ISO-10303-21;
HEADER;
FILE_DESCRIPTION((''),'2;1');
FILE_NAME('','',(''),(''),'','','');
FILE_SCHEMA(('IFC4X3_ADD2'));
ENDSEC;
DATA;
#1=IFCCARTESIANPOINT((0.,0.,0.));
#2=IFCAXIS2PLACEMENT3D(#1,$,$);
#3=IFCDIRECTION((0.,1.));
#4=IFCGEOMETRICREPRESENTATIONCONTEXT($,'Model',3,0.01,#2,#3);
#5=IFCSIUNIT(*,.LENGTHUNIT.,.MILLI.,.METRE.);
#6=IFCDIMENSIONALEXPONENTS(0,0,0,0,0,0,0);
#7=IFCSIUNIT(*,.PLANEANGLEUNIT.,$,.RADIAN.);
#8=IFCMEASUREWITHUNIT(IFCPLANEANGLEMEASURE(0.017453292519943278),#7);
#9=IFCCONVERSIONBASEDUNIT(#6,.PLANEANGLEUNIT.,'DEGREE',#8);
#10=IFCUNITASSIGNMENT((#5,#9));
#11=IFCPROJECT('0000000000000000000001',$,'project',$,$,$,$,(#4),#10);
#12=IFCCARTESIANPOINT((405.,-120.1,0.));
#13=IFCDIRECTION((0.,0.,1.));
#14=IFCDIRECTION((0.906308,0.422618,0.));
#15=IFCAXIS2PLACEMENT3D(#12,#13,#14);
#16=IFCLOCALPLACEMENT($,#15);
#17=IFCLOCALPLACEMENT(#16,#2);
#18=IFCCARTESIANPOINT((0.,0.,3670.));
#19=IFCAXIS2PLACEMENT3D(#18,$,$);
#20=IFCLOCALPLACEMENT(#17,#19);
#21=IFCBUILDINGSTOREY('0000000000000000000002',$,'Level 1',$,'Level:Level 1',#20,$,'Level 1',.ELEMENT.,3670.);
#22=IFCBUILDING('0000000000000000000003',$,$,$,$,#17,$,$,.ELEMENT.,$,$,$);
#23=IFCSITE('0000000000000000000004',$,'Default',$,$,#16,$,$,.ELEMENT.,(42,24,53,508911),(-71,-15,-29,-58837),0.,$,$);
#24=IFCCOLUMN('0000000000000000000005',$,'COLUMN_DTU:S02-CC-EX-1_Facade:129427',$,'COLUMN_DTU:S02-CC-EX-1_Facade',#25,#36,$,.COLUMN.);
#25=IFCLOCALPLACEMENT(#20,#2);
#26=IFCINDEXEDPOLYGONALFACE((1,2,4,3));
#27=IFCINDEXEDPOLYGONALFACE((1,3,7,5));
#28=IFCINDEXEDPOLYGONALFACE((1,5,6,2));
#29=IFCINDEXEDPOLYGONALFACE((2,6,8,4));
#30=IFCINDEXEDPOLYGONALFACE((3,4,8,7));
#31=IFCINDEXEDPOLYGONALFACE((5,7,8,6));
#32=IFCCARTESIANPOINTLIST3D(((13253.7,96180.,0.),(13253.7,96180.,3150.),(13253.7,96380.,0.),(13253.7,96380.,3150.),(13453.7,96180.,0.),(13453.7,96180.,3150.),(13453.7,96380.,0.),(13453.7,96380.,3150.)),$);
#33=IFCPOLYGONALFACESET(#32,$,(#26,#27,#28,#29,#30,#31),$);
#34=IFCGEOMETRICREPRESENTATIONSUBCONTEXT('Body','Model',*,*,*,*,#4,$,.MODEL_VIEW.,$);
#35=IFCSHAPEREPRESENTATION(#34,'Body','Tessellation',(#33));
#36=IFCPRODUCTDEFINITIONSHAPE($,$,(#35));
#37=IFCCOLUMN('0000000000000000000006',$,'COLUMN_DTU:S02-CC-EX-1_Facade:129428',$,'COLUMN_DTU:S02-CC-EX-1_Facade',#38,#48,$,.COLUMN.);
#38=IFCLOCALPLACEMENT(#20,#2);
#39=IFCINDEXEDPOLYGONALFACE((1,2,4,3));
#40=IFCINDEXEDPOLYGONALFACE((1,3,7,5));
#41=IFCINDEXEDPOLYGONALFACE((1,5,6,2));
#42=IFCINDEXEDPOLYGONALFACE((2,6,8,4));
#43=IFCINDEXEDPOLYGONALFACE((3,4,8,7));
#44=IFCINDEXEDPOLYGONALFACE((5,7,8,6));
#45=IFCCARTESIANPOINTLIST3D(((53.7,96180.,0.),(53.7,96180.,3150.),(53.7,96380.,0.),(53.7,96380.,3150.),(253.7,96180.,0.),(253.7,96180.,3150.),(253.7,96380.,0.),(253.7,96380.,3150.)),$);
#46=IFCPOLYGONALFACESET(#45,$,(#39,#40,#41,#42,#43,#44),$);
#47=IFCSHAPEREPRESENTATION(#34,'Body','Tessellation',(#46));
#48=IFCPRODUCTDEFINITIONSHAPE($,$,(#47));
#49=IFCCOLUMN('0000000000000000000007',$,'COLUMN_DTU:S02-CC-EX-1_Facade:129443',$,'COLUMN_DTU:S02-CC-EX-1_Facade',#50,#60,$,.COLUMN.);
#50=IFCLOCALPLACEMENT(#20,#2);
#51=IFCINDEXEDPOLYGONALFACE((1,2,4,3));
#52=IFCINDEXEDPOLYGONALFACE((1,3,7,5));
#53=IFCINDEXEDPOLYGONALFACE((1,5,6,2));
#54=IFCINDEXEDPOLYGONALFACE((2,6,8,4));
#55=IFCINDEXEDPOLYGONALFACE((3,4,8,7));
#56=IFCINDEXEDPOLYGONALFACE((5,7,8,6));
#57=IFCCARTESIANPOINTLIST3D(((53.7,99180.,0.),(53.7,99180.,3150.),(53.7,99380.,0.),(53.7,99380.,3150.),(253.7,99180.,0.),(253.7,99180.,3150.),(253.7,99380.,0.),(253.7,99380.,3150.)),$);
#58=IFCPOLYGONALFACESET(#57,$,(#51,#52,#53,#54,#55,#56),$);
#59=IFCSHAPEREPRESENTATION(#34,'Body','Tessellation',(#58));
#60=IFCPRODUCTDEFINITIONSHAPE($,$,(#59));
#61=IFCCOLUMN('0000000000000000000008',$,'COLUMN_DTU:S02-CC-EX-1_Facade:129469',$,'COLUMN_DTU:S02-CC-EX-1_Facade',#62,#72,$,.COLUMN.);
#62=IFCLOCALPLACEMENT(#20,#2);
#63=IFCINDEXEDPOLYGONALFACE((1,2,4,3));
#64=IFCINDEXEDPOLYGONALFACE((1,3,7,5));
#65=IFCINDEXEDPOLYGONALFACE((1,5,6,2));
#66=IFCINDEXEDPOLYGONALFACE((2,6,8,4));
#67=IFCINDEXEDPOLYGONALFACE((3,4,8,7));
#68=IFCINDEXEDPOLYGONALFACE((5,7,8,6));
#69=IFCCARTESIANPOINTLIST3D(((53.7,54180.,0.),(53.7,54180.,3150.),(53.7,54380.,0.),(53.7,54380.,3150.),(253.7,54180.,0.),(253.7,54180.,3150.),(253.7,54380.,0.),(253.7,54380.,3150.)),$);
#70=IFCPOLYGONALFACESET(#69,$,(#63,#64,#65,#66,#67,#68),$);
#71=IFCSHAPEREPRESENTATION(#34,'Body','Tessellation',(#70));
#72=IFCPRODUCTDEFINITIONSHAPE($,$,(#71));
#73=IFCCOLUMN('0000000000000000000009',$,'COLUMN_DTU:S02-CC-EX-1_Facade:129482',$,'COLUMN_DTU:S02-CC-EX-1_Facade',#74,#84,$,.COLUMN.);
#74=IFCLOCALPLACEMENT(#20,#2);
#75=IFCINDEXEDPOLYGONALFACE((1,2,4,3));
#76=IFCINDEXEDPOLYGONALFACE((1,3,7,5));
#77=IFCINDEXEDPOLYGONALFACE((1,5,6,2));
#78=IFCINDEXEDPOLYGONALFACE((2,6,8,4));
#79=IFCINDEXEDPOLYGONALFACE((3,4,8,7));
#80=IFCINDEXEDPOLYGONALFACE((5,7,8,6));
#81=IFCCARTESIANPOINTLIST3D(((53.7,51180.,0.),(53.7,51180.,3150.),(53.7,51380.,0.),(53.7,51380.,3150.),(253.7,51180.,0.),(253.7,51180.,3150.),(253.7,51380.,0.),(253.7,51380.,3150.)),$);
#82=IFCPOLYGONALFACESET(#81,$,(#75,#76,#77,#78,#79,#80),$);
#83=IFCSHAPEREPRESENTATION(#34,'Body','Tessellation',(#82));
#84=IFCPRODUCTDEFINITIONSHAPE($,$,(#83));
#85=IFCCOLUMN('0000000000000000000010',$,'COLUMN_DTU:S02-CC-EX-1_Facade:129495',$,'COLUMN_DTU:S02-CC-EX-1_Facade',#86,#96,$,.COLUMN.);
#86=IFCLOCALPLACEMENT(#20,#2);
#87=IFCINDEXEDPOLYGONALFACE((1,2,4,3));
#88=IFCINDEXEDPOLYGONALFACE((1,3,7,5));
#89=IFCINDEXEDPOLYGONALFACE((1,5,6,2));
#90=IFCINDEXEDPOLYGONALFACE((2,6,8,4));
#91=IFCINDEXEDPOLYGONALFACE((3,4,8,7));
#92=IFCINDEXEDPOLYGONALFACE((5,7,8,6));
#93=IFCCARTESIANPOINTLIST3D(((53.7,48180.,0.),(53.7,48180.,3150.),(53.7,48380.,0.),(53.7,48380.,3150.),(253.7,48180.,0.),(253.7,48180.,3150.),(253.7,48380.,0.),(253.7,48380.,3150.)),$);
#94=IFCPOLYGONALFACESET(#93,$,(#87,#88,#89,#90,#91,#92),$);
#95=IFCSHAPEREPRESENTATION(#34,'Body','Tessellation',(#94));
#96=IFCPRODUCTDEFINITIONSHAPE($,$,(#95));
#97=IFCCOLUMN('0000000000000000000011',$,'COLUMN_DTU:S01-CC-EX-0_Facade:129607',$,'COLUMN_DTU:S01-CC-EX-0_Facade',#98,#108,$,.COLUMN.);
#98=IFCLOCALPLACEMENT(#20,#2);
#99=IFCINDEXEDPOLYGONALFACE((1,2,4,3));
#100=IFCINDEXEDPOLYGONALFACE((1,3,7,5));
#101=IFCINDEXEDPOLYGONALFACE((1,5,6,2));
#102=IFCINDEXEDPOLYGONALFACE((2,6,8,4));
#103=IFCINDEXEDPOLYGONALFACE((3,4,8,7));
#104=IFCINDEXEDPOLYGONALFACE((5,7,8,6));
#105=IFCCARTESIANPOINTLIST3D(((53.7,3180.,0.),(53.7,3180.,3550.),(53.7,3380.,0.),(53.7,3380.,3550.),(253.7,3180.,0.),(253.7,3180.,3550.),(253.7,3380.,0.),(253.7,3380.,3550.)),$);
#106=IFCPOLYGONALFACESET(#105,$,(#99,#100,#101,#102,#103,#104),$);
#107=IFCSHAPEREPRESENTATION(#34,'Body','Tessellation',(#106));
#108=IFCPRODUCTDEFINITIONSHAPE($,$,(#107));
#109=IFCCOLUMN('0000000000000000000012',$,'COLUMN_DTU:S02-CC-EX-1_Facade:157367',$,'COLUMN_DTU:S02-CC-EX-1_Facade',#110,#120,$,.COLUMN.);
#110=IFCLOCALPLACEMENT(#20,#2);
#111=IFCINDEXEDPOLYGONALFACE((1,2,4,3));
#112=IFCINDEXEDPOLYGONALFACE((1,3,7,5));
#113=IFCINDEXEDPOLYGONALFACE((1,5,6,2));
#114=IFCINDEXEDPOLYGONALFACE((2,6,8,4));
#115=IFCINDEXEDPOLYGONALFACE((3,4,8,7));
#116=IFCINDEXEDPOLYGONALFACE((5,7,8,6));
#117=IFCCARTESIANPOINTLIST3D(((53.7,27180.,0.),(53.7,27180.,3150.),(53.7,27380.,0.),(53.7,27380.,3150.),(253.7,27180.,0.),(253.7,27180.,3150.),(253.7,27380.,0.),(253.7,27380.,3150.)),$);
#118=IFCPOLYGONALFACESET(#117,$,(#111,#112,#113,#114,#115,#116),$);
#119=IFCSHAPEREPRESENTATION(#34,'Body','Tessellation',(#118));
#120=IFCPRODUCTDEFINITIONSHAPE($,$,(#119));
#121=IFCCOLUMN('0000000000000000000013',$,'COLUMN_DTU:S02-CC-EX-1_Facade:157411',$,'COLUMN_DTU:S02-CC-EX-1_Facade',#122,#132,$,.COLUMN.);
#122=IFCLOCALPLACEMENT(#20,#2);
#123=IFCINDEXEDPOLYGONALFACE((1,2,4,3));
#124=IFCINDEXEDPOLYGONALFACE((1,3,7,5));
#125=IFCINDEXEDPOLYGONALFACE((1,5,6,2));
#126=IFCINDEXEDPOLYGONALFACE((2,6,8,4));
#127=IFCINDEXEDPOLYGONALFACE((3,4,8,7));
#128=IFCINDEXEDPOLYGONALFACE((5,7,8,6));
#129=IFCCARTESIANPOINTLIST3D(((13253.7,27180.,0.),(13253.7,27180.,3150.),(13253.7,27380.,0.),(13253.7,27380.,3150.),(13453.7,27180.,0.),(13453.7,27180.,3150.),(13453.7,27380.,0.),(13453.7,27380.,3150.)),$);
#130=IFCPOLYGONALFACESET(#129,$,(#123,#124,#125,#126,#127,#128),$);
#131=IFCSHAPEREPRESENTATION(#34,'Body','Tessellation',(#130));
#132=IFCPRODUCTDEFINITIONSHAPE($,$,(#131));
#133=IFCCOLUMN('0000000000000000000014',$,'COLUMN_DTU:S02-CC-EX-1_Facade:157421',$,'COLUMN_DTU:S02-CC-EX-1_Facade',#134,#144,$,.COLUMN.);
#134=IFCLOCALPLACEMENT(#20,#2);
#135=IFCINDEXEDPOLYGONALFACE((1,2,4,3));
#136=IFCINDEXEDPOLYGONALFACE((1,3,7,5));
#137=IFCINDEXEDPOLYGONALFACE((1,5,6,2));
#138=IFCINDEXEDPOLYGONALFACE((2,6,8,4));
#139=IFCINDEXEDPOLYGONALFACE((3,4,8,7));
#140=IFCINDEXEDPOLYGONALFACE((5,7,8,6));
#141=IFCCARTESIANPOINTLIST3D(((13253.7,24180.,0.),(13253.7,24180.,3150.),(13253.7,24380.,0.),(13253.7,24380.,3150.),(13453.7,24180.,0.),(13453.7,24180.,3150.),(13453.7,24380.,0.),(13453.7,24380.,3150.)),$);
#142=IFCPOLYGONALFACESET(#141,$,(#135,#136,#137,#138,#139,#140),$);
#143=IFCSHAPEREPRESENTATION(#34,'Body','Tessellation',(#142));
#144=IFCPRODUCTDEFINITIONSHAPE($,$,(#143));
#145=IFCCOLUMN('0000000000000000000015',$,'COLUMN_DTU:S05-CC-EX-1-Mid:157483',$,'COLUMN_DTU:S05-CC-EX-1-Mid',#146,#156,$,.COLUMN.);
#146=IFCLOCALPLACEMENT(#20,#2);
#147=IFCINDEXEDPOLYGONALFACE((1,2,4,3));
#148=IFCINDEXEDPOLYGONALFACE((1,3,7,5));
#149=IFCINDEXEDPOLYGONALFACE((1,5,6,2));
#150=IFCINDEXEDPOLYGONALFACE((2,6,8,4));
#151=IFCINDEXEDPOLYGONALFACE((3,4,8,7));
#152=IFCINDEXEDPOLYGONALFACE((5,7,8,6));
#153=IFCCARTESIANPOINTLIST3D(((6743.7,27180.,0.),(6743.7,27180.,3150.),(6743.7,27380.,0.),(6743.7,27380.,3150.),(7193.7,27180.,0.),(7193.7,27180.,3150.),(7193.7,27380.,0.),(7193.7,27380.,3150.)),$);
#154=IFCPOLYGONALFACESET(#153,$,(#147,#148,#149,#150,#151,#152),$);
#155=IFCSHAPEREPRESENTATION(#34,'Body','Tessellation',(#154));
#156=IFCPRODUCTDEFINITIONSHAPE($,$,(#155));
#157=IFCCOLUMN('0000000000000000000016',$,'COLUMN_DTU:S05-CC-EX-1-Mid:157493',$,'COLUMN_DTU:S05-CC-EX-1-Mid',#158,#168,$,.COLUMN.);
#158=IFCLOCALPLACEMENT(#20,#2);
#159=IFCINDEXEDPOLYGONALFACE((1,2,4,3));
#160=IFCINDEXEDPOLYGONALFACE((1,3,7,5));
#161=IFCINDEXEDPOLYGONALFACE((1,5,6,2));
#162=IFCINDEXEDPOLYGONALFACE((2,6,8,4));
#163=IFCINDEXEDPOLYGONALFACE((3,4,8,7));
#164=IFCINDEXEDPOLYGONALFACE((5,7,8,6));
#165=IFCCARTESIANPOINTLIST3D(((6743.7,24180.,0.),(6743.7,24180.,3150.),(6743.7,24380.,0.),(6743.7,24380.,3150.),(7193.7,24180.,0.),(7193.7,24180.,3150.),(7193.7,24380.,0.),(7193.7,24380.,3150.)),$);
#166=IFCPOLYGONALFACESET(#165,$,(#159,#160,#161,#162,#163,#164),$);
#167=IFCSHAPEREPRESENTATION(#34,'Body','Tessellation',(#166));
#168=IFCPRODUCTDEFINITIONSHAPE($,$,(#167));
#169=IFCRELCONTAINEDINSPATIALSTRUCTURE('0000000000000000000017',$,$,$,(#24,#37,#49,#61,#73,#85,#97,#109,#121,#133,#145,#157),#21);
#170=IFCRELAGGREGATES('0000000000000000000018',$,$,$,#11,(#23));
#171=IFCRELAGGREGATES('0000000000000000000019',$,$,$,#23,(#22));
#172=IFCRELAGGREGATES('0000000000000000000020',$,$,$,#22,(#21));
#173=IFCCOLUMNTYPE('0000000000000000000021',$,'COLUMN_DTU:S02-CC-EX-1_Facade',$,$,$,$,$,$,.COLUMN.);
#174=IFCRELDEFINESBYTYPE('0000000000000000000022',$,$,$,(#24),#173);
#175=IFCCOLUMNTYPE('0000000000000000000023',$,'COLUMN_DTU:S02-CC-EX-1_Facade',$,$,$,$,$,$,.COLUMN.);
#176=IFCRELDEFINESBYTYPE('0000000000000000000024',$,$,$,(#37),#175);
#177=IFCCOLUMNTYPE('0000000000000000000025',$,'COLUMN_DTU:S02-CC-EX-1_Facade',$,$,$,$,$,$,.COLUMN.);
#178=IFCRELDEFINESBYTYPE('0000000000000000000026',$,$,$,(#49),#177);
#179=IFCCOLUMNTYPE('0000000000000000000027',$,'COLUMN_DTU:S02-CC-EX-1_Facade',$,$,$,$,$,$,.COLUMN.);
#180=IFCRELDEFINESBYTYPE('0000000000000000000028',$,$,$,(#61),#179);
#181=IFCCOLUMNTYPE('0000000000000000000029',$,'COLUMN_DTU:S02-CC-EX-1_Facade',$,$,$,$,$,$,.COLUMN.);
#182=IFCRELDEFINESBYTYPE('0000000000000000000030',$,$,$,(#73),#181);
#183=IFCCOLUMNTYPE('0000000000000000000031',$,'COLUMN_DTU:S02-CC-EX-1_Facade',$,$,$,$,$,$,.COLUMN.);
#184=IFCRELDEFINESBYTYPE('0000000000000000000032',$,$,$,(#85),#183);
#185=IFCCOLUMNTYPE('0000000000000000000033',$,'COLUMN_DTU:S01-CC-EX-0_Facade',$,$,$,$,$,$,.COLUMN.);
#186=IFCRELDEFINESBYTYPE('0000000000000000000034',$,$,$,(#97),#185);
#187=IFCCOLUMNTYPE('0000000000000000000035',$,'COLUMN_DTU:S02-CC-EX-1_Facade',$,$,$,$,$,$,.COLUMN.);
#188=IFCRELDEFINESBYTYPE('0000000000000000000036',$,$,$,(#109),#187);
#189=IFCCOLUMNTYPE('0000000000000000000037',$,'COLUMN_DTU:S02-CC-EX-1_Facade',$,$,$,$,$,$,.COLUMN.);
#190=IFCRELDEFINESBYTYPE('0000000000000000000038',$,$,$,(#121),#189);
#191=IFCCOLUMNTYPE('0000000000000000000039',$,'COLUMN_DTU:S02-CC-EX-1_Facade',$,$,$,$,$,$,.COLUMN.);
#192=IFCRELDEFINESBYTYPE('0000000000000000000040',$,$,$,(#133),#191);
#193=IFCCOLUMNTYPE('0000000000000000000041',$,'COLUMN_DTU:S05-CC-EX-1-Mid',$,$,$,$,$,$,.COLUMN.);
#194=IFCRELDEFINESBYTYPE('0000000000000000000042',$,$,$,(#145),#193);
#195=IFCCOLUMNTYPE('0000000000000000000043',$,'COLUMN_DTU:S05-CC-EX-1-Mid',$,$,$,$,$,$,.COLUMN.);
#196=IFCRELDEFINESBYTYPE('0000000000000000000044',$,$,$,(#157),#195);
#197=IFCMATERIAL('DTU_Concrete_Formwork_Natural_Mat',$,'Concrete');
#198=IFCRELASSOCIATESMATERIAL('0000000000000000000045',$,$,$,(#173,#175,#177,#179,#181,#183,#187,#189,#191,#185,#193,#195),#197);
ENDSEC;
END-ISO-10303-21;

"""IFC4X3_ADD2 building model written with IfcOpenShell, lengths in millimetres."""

from ifc_helpers import new_model, entity, si_unit, converted_unit, direction, frame, frame_2d, origin, origin_2d_with_axis, place, context, subcontext, project, spatial, rectangle, extrude, source, transform, mapped, material, material_profile, profile_set, type_object, type_shapes, element, save


model = new_model("IFC4X3_ADD2")

# Units and contexts
model_context = context("Model", 3, precision=0.01, world=origin(), true_north=direction((0.0, 1.0)))
body_context = subcontext(model_context, "Body", "Model", "MODEL_VIEW")
ifc_project = project(units=[si_unit("LENGTHUNIT", "METRE", prefix="MILLI"), converted_unit("PLANEANGLEUNIT", "DEGREE", entity("IfcPlaneAngleMeasure", 0.017453292519943278), si_unit("PLANEANGLEUNIT", "RADIAN"), dimensions=[0, 0, 0, 0, 0, 0, 0])], contexts=[model_context])

# Site, building, storey
site_placement = place(None, frame((405.0, -120.1, 0.0), z_axis=(0.0, 0.0, 1.0), x_axis=(0.906308, 0.422618, 0.0)))
site = spatial("IfcSite", under=ifc_project, at=site_placement, Name="Default", CompositionType="ELEMENT", RefLatitude=(42, 24, 53, 508911), RefLongitude=(-71, -15, -29, -58837), RefElevation=0.0)
building_placement = place(site_placement, origin())
building = spatial("IfcBuilding", under=site, at=building_placement, CompositionType="ELEMENT")
storey_placement = place(building_placement, frame((0.0, 0.0, 3670.0)))
storey = spatial("IfcBuildingStorey", under=building, at=storey_placement, Name="Level 1", ObjectType="Level:Level 1", LongName="Level 1", CompositionType="ELEMENT", Elevation=3670.0)

# Columns
ifc_material = material(Name="DTU_Concrete_Formwork_Natural_Mat", Category="Concrete")
ifc_material_profile_1 = material_profile(ifc_material, rectangle(XDim=200.0, YDim=200.0, at=frame_2d((0.0, 0.0), x_axis=(1.0, 0.0))), Name="S02-CC-EX-1_Facade")
ifc_profile_set_1 = profile_set([ifc_material_profile_1], Name="S02-CC-EX-1_Facade")
column_type_1 = type_object("IfcColumnType", Name="COLUMN_DTU:S02-CC-EX-1_Facade", PredefinedType="COLUMN", material=ifc_profile_set_1)
shared_shape_1 = source(origin(), body_context, "Body", "SweptSolid", [
    extrude(rectangle(XDim=200.0, YDim=200.0, at=frame_2d((0.0, 0.0), x_axis=(1.0, 0.0))), frame((13353.7, 96280.0, 3670.0), z_axis=(0.0, 0.0, 1.0), x_axis=(0.0, -1.0, 0.0)), (0.0, 0.0, 1.0), 3150.0),
])
type_shapes(column_type_1, [shared_shape_1])
column_1_placement = place(storey_placement, frame((0.0, 0.0, -3670.0)))
element("IfcColumn", 1, at=column_1_placement, inside=storey, type_object=column_type_1, Name="COLUMN_DTU:S02-CC-EX-1_Facade:129427", ObjectType="COLUMN_DTU:S02-CC-EX-1_Facade", PredefinedType="COLUMN", context=body_context, shape_type="MappedRepresentation", body=[
    mapped(shared_shape_1, transform((0.0, 0.0, 0.0), scale=1.0)),
])
column_type_2 = type_object("IfcColumnType", Name="COLUMN_DTU:S02-CC-EX-1_Facade", PredefinedType="COLUMN", material=ifc_profile_set_1)
shared_shape_2 = source(origin(), body_context, "Body", "SweptSolid", [
    extrude(rectangle(XDim=200.0, YDim=200.0, at=frame_2d((0.0, 0.0), x_axis=(1.0, 0.0))), frame((153.7, 96280.0, 3670.0), z_axis=(0.0, 0.0, 1.0), x_axis=(0.0, -1.0, 0.0)), (0.0, 0.0, 1.0), 3150.0),
])
type_shapes(column_type_2, [shared_shape_2])
column_2_placement = place(storey_placement, frame((0.0, 0.0, -3670.0)))
element("IfcColumn", 2, at=column_2_placement, inside=storey, type_object=column_type_2, Name="COLUMN_DTU:S02-CC-EX-1_Facade:129428", ObjectType="COLUMN_DTU:S02-CC-EX-1_Facade", PredefinedType="COLUMN", context=body_context, shape_type="MappedRepresentation", body=[
    mapped(shared_shape_2, transform((0.0, 0.0, 0.0), scale=1.0)),
])
column_type_3 = type_object("IfcColumnType", Name="COLUMN_DTU:S02-CC-EX-1_Facade", PredefinedType="COLUMN", material=ifc_profile_set_1)
shared_shape_3 = source(origin(), body_context, "Body", "SweptSolid", [
    extrude(rectangle(XDim=200.0, YDim=200.0, at=frame_2d((0.0, 0.0), x_axis=(1.0, 0.0))), frame((153.7, 99280.0, 3670.0), z_axis=(0.0, 0.0, 1.0), x_axis=(0.0, -1.0, 0.0)), (0.0, 0.0, 1.0), 3150.0),
])
type_shapes(column_type_3, [shared_shape_3])
column_3_placement = place(storey_placement, frame((0.0, 0.0, -3670.0)))
element("IfcColumn", 3, at=column_3_placement, inside=storey, type_object=column_type_3, Name="COLUMN_DTU:S02-CC-EX-1_Facade:129443", ObjectType="COLUMN_DTU:S02-CC-EX-1_Facade", PredefinedType="COLUMN", context=body_context, shape_type="MappedRepresentation", body=[
    mapped(shared_shape_3, transform((0.0, 0.0, 0.0), scale=1.0)),
])
column_type_4 = type_object("IfcColumnType", Name="COLUMN_DTU:S02-CC-EX-1_Facade", PredefinedType="COLUMN", material=ifc_profile_set_1)
shared_shape_4 = source(origin(), body_context, "Body", "SweptSolid", [
    extrude(rectangle(XDim=200.0, YDim=200.0, at=frame_2d((0.0, 0.0), x_axis=(1.0, 0.0))), frame((153.7, 54280.0, 3670.0), z_axis=(0.0, 0.0, 1.0), x_axis=(0.0, -1.0, 0.0)), (0.0, 0.0, 1.0), 3150.0),
])
type_shapes(column_type_4, [shared_shape_4])
column_4_placement = place(storey_placement, frame((0.0, 0.0, -3670.0)))
element("IfcColumn", 4, at=column_4_placement, inside=storey, type_object=column_type_4, Name="COLUMN_DTU:S02-CC-EX-1_Facade:129469", ObjectType="COLUMN_DTU:S02-CC-EX-1_Facade", PredefinedType="COLUMN", context=body_context, shape_type="MappedRepresentation", body=[
    mapped(shared_shape_4, transform((0.0, 0.0, 0.0), scale=1.0)),
])
column_type_5 = type_object("IfcColumnType", Name="COLUMN_DTU:S02-CC-EX-1_Facade", PredefinedType="COLUMN", material=ifc_profile_set_1)
shared_shape_5 = source(origin(), body_context, "Body", "SweptSolid", [
    extrude(rectangle(XDim=200.0, YDim=200.0, at=frame_2d((0.0, 0.0), x_axis=(1.0, 0.0))), frame((153.7, 51280.0, 3670.0), z_axis=(0.0, 0.0, 1.0), x_axis=(0.0, -1.0, 0.0)), (0.0, 0.0, 1.0), 3150.0),
])
type_shapes(column_type_5, [shared_shape_5])
column_5_placement = place(storey_placement, frame((0.0, 0.0, -3670.0)))
element("IfcColumn", 5, at=column_5_placement, inside=storey, type_object=column_type_5, Name="COLUMN_DTU:S02-CC-EX-1_Facade:129482", ObjectType="COLUMN_DTU:S02-CC-EX-1_Facade", PredefinedType="COLUMN", context=body_context, shape_type="MappedRepresentation", body=[
    mapped(shared_shape_5, transform((0.0, 0.0, 0.0), scale=1.0)),
])
column_type_6 = type_object("IfcColumnType", Name="COLUMN_DTU:S02-CC-EX-1_Facade", PredefinedType="COLUMN", material=ifc_profile_set_1)
shared_shape_6 = source(origin(), body_context, "Body", "SweptSolid", [
    extrude(rectangle(XDim=200.0, YDim=200.0, at=frame_2d((0.0, 0.0), x_axis=(1.0, 0.0))), frame((153.7, 48280.0, 3670.0), z_axis=(0.0, 0.0, 1.0), x_axis=(0.0, -1.0, 0.0)), (0.0, 0.0, 1.0), 3150.0),
])
type_shapes(column_type_6, [shared_shape_6])
column_6_placement = place(storey_placement, frame((0.0, 0.0, -3670.0)))
element("IfcColumn", 6, at=column_6_placement, inside=storey, type_object=column_type_6, Name="COLUMN_DTU:S02-CC-EX-1_Facade:129495", ObjectType="COLUMN_DTU:S02-CC-EX-1_Facade", PredefinedType="COLUMN", context=body_context, shape_type="MappedRepresentation", body=[
    mapped(shared_shape_6, transform((0.0, 0.0, 0.0), scale=1.0)),
])
ifc_material_profile_2 = material_profile(ifc_material, rectangle(XDim=200.0, YDim=200.0, at=frame_2d((0.0, 0.0), x_axis=(1.0, 0.0))), Name="S01-CC-EX-0_Facade")
ifc_profile_set_2 = profile_set([ifc_material_profile_2], Name="S01-CC-EX-0_Facade")
column_type_7 = type_object("IfcColumnType", Name="COLUMN_DTU:S01-CC-EX-0_Facade", PredefinedType="COLUMN", material=ifc_profile_set_2)
shared_shape_7 = source(origin(), body_context, "Body", "SweptSolid", [
    extrude(rectangle(XDim=200.0, YDim=200.0, at=frame_2d((0.0, 0.0), x_axis=(1.0, 0.0))), frame((153.7, 3280.0, 3670.0), z_axis=(0.0, 0.0, 1.0), x_axis=(0.0, -1.0, 0.0)), (0.0, 0.0, 1.0), 3550.0),
])
type_shapes(column_type_7, [shared_shape_7])
column_7_placement = place(storey_placement, frame((0.0, 0.0, -3670.0)))
element("IfcColumn", 7, at=column_7_placement, inside=storey, type_object=column_type_7, Name="COLUMN_DTU:S01-CC-EX-0_Facade:129607", ObjectType="COLUMN_DTU:S01-CC-EX-0_Facade", PredefinedType="COLUMN", context=body_context, shape_type="MappedRepresentation", body=[
    mapped(shared_shape_7, transform((0.0, 0.0, 0.0), scale=1.0)),
])
column_type_8 = type_object("IfcColumnType", Name="COLUMN_DTU:S02-CC-EX-1_Facade", PredefinedType="COLUMN", material=ifc_profile_set_1)
shared_shape_8 = source(origin(), body_context, "Body", "SweptSolid", [
    extrude(rectangle(XDim=200.0, YDim=200.0, at=frame_2d((0.0, 0.0), x_axis=(1.0, 0.0))), frame((153.7, 27280.0, 3670.0), z_axis=(0.0, 0.0, 1.0), x_axis=(0.0, -1.0, 0.0)), (0.0, 0.0, 1.0), 3150.0),
])
type_shapes(column_type_8, [shared_shape_8])
column_8_placement = place(storey_placement, frame((0.0, 0.0, -3670.0)))
element("IfcColumn", 8, at=column_8_placement, inside=storey, type_object=column_type_8, Name="COLUMN_DTU:S02-CC-EX-1_Facade:157367", ObjectType="COLUMN_DTU:S02-CC-EX-1_Facade", PredefinedType="COLUMN", context=body_context, shape_type="MappedRepresentation", body=[
    mapped(shared_shape_8, transform((0.0, 0.0, 0.0), scale=1.0)),
])
column_type_9 = type_object("IfcColumnType", Name="COLUMN_DTU:S02-CC-EX-1_Facade", PredefinedType="COLUMN", material=ifc_profile_set_1)
shared_shape_9 = source(origin(), body_context, "Body", "SweptSolid", [
    extrude(rectangle(XDim=200.0, YDim=200.0, at=frame_2d((0.0, 0.0), x_axis=(1.0, 0.0))), frame((13353.7, 27280.0, 3670.0), z_axis=(0.0, 0.0, 1.0), x_axis=(0.0, -1.0, 0.0)), (0.0, 0.0, 1.0), 3150.0),
])
type_shapes(column_type_9, [shared_shape_9])
column_9_placement = place(storey_placement, frame((0.0, 0.0, -3670.0)))
element("IfcColumn", 9, at=column_9_placement, inside=storey, type_object=column_type_9, Name="COLUMN_DTU:S02-CC-EX-1_Facade:157411", ObjectType="COLUMN_DTU:S02-CC-EX-1_Facade", PredefinedType="COLUMN", context=body_context, shape_type="MappedRepresentation", body=[
    mapped(shared_shape_9, transform((0.0, 0.0, 0.0), scale=1.0)),
])
column_type_10 = type_object("IfcColumnType", Name="COLUMN_DTU:S02-CC-EX-1_Facade", PredefinedType="COLUMN", material=ifc_profile_set_1)
shared_shape_10 = source(origin(), body_context, "Body", "SweptSolid", [
    extrude(rectangle(XDim=200.0, YDim=200.0, at=frame_2d((0.0, 0.0), x_axis=(1.0, 0.0))), frame((13353.7, 24280.0, 3670.0), z_axis=(0.0, 0.0, 1.0), x_axis=(0.0, -1.0, 0.0)), (0.0, 0.0, 1.0), 3150.0),
])
type_shapes(column_type_10, [shared_shape_10])
column_10_placement = place(storey_placement, frame((0.0, 0.0, -3670.0)))
element("IfcColumn", 10, at=column_10_placement, inside=storey, type_object=column_type_10, Name="COLUMN_DTU:S02-CC-EX-1_Facade:157421", ObjectType="COLUMN_DTU:S02-CC-EX-1_Facade", PredefinedType="COLUMN", context=body_context, shape_type="MappedRepresentation", body=[
    mapped(shared_shape_10, transform((0.0, 0.0, 0.0), scale=1.0)),
])
ifc_material_profile_3 = material_profile(ifc_material, rectangle(XDim=200.0, YDim=450.0, at=origin_2d_with_axis()), Name="S05-CC-EX-1-Mid")
ifc_profile_set_3 = profile_set([ifc_material_profile_3], Name="S05-CC-EX-1-Mid")
column_type_11 = type_object("IfcColumnType", Name="COLUMN_DTU:S05-CC-EX-1-Mid", PredefinedType="COLUMN", material=ifc_profile_set_3)
shared_shape_11 = source(origin(), body_context, "Body", "SweptSolid", [
    extrude(rectangle(XDim=200.0, YDim=450.0, at=origin_2d_with_axis()), frame((6968.7, 27280.0, 3670.0), z_axis=(0.0, 0.0, 1.0), x_axis=(0.0, 1.0, 0.0)), (0.0, 0.0, 1.0), 3150.0),
])
type_shapes(column_type_11, [shared_shape_11])
column_11_placement = place(storey_placement, frame((0.0, 0.0, -3670.0)))
element("IfcColumn", 11, at=column_11_placement, inside=storey, type_object=column_type_11, Name="COLUMN_DTU:S05-CC-EX-1-Mid:157483", ObjectType="COLUMN_DTU:S05-CC-EX-1-Mid", PredefinedType="COLUMN", context=body_context, shape_type="MappedRepresentation", body=[
    mapped(shared_shape_11, transform((0.0, 0.0, 0.0), scale=1.0)),
])
column_type_12 = type_object("IfcColumnType", Name="COLUMN_DTU:S05-CC-EX-1-Mid", PredefinedType="COLUMN", material=ifc_profile_set_3)
shared_shape_12 = source(origin(), body_context, "Body", "SweptSolid", [
    extrude(rectangle(XDim=200.0, YDim=450.0, at=origin_2d_with_axis()), frame((6968.7, 24280.0, 3670.0), z_axis=(0.0, 0.0, 1.0), x_axis=(0.0, 1.0, 0.0)), (0.0, 0.0, 1.0), 3150.0),
])
type_shapes(column_type_12, [shared_shape_12])
column_12_placement = place(storey_placement, frame((0.0, 0.0, -3670.0)))
element("IfcColumn", 12, at=column_12_placement, inside=storey, type_object=column_type_12, Name="COLUMN_DTU:S05-CC-EX-1-Mid:157493", ObjectType="COLUMN_DTU:S05-CC-EX-1-Mid", PredefinedType="COLUMN", context=body_context, shape_type="MappedRepresentation", body=[
    mapped(shared_shape_12, transform((0.0, 0.0, 0.0), scale=1.0)),
])

save(model, "model.ifc")
